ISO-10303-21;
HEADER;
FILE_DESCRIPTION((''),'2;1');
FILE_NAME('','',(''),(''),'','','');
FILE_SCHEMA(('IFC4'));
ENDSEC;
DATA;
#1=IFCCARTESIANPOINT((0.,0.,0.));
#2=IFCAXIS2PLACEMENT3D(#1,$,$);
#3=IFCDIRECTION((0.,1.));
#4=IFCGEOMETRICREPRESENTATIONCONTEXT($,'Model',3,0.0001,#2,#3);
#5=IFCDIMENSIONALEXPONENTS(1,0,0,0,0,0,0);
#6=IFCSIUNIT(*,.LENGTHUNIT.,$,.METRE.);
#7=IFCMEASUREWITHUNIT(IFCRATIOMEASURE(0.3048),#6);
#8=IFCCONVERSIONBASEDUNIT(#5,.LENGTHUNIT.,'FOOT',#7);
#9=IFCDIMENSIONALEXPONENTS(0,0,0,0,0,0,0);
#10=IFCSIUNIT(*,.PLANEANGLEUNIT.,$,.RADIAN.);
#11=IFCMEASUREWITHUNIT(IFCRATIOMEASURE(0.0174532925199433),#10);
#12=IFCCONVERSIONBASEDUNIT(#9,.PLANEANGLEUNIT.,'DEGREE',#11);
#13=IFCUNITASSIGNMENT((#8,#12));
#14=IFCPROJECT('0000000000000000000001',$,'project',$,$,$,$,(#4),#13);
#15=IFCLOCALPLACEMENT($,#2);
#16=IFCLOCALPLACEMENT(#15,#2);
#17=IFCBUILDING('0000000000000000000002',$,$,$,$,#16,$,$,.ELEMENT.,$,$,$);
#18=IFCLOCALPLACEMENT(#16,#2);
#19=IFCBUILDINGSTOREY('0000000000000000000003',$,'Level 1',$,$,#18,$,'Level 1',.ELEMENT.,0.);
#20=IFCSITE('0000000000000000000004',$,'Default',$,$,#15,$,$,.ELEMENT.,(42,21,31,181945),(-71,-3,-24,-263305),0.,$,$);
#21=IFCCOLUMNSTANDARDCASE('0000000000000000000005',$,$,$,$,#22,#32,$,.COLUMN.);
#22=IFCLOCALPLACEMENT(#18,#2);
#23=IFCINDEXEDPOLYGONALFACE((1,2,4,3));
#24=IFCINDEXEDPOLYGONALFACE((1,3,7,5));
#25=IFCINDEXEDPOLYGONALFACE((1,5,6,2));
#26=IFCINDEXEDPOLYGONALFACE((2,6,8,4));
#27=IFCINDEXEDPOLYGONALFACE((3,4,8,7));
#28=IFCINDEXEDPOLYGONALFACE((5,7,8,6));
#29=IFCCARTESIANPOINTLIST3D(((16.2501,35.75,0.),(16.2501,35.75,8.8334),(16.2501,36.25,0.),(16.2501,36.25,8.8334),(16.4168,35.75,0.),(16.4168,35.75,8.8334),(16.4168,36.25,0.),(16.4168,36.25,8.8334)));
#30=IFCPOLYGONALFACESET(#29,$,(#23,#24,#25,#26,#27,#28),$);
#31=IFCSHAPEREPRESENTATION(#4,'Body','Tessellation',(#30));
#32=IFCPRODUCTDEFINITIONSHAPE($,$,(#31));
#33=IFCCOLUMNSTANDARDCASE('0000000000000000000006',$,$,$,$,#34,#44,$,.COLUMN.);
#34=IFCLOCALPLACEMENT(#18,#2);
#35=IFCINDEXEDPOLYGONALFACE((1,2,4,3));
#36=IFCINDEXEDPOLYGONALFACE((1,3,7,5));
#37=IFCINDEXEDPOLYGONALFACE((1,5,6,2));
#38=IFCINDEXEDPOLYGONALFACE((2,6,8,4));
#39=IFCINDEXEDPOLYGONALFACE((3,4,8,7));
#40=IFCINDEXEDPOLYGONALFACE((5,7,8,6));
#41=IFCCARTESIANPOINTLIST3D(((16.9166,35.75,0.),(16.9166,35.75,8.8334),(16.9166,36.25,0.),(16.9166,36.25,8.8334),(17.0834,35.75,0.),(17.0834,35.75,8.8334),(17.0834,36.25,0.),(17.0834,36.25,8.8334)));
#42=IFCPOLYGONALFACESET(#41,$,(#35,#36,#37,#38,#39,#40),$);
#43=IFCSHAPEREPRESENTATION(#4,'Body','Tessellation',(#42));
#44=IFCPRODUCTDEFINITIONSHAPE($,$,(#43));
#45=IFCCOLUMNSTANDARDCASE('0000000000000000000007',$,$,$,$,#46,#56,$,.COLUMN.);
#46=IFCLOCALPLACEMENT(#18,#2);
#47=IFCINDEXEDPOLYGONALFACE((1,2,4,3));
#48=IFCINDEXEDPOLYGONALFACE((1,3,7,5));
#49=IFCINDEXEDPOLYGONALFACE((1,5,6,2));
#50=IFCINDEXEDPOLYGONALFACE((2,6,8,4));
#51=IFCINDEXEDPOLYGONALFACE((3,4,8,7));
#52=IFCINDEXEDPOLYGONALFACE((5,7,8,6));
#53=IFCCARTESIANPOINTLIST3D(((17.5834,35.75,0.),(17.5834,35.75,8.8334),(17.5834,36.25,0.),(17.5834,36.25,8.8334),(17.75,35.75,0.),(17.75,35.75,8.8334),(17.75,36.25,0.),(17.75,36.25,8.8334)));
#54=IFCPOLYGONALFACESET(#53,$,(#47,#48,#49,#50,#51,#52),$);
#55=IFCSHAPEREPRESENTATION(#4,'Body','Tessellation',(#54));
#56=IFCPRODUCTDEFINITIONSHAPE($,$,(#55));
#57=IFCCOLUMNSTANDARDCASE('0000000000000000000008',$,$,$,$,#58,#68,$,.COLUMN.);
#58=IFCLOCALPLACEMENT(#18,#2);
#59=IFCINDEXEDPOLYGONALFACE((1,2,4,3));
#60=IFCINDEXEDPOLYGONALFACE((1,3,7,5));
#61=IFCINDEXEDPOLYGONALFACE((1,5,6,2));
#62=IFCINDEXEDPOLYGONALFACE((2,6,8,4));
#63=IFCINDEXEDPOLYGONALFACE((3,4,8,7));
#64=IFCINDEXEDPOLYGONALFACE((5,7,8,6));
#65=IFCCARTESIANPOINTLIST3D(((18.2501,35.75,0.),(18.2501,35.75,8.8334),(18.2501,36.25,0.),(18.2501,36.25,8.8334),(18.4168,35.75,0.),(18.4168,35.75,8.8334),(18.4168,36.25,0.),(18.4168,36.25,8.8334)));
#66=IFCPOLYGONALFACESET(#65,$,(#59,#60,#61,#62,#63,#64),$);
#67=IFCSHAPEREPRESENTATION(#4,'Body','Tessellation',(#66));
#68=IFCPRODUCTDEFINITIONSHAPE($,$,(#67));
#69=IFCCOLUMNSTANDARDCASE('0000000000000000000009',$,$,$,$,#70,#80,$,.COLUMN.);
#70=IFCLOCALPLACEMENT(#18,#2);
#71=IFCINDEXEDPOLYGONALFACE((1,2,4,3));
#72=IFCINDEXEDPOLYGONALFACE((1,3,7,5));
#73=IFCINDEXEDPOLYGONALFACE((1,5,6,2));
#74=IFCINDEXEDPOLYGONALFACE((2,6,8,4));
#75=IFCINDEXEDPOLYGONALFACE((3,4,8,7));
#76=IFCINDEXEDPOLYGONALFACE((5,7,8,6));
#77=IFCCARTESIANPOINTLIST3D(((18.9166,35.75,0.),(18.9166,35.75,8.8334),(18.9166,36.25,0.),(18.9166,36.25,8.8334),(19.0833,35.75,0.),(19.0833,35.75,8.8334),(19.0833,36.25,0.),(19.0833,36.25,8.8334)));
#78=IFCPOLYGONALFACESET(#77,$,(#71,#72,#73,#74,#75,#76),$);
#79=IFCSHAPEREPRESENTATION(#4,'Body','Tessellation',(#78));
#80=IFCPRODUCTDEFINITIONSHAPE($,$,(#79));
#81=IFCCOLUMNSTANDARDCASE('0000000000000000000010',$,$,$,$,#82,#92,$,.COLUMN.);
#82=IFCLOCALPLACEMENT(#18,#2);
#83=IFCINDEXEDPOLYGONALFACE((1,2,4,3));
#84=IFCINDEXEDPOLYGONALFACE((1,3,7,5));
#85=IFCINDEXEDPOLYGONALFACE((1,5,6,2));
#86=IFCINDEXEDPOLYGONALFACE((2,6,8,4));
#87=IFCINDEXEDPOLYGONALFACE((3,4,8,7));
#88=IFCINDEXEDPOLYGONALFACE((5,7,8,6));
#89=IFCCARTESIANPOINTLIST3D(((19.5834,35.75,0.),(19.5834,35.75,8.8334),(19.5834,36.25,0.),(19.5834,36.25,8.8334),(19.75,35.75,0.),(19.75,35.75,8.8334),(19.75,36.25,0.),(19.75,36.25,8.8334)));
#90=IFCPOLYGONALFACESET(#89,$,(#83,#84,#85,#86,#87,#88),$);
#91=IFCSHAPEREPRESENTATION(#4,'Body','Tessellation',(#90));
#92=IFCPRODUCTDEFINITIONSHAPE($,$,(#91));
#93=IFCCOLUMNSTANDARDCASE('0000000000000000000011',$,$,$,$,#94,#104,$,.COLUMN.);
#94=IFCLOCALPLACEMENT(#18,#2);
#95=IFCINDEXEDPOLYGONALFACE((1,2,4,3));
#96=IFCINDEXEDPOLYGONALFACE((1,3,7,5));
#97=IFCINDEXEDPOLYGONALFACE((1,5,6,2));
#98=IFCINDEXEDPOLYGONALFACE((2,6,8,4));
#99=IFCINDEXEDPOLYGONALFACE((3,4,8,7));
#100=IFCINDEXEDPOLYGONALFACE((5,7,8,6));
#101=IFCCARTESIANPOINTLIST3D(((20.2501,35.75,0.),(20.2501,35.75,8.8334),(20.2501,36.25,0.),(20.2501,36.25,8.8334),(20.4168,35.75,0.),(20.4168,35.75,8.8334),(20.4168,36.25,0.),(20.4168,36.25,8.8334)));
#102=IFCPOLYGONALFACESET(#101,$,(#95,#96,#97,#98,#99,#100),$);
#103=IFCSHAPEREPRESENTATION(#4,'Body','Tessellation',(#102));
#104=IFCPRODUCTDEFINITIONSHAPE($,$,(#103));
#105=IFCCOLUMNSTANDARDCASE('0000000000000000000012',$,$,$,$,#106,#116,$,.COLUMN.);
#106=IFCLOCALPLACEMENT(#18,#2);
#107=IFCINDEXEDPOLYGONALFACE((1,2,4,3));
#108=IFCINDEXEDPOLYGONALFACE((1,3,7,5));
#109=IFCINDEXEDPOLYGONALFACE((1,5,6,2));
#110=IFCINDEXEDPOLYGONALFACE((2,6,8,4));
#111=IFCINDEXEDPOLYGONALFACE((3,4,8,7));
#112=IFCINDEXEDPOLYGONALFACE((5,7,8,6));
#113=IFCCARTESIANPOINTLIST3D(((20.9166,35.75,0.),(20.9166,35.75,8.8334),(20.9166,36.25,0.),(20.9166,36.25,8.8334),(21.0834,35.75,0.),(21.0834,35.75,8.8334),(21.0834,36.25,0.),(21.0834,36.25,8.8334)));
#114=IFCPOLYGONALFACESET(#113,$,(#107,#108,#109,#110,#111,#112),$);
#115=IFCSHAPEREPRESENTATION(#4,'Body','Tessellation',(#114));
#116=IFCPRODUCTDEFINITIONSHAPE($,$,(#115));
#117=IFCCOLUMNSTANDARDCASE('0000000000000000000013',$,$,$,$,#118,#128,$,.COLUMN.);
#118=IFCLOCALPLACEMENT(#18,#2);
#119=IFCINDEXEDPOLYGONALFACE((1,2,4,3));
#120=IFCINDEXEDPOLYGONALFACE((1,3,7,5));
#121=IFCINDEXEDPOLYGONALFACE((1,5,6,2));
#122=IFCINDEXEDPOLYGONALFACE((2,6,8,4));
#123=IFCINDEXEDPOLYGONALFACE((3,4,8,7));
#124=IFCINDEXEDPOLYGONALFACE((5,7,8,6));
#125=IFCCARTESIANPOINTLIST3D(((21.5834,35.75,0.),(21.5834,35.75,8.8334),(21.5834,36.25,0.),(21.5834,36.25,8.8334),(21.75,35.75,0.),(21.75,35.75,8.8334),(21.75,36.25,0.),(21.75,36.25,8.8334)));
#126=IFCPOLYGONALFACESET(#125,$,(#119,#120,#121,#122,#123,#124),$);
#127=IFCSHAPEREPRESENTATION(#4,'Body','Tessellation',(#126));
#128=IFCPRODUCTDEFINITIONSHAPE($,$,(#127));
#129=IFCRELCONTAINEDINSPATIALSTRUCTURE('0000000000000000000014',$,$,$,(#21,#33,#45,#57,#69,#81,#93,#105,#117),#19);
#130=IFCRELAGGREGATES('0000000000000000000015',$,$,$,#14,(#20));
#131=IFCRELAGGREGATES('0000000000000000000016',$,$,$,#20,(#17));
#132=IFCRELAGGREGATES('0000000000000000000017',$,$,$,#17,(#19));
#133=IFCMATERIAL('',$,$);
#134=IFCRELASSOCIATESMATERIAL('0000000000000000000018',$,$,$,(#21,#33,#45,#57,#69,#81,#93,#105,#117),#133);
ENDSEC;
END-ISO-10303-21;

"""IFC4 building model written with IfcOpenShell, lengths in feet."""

from ifc_helpers import new_model, entity, si_unit, converted_unit, direction, frame, origin, place, context, project, spatial, rectangle, extrude, material, element, save


model = new_model("IFC4")

# Units and contexts
model_context = context("Model", 3, precision=0.0001, world=origin(), true_north=direction((0.0, 1.0)))
ifc_project = project(units=[converted_unit("LENGTHUNIT", "FOOT", entity("IfcRatioMeasure", 0.3048), si_unit("LENGTHUNIT", "METRE"), dimensions=[1, 0, 0, 0, 0, 0, 0]), converted_unit("PLANEANGLEUNIT", "DEGREE", entity("IfcRatioMeasure", 0.0174532925199433), si_unit("PLANEANGLEUNIT", "RADIAN"), dimensions=[0, 0, 0, 0, 0, 0, 0])], contexts=[model_context])

# Site, building, storey
site_placement = place(None, origin())
site = spatial("IfcSite", under=ifc_project, at=site_placement, Name="Default", CompositionType="ELEMENT", RefLatitude=(42, 21, 31, 181945), RefLongitude=(-71, -3, -24, -263305), RefElevation=0.0)
building_placement = place(site_placement, origin())
building = spatial("IfcBuilding", under=site, at=building_placement, CompositionType="ELEMENT")
storey_placement = place(building_placement, origin())
storey = spatial("IfcBuildingStorey", under=building, at=storey_placement, Name="Level 1", LongName="Level 1", CompositionType="ELEMENT", Elevation=0.0)

# Columns
ifc_material_1 = material(Name="")
placement_1 = place(storey_placement, frame((0.25, 36.0, 0.0)))
for number, where, z_axis, x_axis in (
    (1, (16.0834, 0.0, 0.0), (0.0, 0.0, 1.0), (1.0, 0.0, 0.0)),
    (2, (16.75, 0.0, 0.0), (0.0, 0.0, 1.0), (1.0, 0.0, 0.0)),
    (3, (17.4167, 0.0, 0.0), (0.0, 0.0, 1.0), (1.0, 0.0, 0.0)),
    (4, (18.0834, 0.0, 0.0), (0.0, 0.0, 1.0), (1.0, 0.0, 0.0)),
    (5, (18.75, 0.0, 0.0), (0.0, 0.0, 1.0), (1.0, 0.0, 0.0)),
    (6, (19.4167, 0.0, 0.0), (0.0, 0.0, 1.0), (1.0, 0.0, 0.0)),
    (7, (20.0834, 0.0, 0.0), (0.0, 0.0, 1.0), (1.0, 0.0, 0.0)),
    (8, (20.75, 0.0, 0.0), (0.0, 0.0, 1.0), (1.0, 0.0, 0.0)),
    (9, (21.4167, 0.0, 0.0), (0.0, 0.0, 1.0), (1.0, 0.0, 0.0)),
):
    element("IfcColumnStandardCase", number, at=place(placement_1, frame(where, z_axis=z_axis, x_axis=x_axis)), inside=storey, material=ifc_material_1, PredefinedType="COLUMN", context=model_context, shape_type="SweptSolid", body=[
        extrude(rectangle(XDim=0.1667, YDim=0.5), origin(), (0.0, 0.0, 1.0), 8.8334),
    ])

save(model, "model.ifc")
